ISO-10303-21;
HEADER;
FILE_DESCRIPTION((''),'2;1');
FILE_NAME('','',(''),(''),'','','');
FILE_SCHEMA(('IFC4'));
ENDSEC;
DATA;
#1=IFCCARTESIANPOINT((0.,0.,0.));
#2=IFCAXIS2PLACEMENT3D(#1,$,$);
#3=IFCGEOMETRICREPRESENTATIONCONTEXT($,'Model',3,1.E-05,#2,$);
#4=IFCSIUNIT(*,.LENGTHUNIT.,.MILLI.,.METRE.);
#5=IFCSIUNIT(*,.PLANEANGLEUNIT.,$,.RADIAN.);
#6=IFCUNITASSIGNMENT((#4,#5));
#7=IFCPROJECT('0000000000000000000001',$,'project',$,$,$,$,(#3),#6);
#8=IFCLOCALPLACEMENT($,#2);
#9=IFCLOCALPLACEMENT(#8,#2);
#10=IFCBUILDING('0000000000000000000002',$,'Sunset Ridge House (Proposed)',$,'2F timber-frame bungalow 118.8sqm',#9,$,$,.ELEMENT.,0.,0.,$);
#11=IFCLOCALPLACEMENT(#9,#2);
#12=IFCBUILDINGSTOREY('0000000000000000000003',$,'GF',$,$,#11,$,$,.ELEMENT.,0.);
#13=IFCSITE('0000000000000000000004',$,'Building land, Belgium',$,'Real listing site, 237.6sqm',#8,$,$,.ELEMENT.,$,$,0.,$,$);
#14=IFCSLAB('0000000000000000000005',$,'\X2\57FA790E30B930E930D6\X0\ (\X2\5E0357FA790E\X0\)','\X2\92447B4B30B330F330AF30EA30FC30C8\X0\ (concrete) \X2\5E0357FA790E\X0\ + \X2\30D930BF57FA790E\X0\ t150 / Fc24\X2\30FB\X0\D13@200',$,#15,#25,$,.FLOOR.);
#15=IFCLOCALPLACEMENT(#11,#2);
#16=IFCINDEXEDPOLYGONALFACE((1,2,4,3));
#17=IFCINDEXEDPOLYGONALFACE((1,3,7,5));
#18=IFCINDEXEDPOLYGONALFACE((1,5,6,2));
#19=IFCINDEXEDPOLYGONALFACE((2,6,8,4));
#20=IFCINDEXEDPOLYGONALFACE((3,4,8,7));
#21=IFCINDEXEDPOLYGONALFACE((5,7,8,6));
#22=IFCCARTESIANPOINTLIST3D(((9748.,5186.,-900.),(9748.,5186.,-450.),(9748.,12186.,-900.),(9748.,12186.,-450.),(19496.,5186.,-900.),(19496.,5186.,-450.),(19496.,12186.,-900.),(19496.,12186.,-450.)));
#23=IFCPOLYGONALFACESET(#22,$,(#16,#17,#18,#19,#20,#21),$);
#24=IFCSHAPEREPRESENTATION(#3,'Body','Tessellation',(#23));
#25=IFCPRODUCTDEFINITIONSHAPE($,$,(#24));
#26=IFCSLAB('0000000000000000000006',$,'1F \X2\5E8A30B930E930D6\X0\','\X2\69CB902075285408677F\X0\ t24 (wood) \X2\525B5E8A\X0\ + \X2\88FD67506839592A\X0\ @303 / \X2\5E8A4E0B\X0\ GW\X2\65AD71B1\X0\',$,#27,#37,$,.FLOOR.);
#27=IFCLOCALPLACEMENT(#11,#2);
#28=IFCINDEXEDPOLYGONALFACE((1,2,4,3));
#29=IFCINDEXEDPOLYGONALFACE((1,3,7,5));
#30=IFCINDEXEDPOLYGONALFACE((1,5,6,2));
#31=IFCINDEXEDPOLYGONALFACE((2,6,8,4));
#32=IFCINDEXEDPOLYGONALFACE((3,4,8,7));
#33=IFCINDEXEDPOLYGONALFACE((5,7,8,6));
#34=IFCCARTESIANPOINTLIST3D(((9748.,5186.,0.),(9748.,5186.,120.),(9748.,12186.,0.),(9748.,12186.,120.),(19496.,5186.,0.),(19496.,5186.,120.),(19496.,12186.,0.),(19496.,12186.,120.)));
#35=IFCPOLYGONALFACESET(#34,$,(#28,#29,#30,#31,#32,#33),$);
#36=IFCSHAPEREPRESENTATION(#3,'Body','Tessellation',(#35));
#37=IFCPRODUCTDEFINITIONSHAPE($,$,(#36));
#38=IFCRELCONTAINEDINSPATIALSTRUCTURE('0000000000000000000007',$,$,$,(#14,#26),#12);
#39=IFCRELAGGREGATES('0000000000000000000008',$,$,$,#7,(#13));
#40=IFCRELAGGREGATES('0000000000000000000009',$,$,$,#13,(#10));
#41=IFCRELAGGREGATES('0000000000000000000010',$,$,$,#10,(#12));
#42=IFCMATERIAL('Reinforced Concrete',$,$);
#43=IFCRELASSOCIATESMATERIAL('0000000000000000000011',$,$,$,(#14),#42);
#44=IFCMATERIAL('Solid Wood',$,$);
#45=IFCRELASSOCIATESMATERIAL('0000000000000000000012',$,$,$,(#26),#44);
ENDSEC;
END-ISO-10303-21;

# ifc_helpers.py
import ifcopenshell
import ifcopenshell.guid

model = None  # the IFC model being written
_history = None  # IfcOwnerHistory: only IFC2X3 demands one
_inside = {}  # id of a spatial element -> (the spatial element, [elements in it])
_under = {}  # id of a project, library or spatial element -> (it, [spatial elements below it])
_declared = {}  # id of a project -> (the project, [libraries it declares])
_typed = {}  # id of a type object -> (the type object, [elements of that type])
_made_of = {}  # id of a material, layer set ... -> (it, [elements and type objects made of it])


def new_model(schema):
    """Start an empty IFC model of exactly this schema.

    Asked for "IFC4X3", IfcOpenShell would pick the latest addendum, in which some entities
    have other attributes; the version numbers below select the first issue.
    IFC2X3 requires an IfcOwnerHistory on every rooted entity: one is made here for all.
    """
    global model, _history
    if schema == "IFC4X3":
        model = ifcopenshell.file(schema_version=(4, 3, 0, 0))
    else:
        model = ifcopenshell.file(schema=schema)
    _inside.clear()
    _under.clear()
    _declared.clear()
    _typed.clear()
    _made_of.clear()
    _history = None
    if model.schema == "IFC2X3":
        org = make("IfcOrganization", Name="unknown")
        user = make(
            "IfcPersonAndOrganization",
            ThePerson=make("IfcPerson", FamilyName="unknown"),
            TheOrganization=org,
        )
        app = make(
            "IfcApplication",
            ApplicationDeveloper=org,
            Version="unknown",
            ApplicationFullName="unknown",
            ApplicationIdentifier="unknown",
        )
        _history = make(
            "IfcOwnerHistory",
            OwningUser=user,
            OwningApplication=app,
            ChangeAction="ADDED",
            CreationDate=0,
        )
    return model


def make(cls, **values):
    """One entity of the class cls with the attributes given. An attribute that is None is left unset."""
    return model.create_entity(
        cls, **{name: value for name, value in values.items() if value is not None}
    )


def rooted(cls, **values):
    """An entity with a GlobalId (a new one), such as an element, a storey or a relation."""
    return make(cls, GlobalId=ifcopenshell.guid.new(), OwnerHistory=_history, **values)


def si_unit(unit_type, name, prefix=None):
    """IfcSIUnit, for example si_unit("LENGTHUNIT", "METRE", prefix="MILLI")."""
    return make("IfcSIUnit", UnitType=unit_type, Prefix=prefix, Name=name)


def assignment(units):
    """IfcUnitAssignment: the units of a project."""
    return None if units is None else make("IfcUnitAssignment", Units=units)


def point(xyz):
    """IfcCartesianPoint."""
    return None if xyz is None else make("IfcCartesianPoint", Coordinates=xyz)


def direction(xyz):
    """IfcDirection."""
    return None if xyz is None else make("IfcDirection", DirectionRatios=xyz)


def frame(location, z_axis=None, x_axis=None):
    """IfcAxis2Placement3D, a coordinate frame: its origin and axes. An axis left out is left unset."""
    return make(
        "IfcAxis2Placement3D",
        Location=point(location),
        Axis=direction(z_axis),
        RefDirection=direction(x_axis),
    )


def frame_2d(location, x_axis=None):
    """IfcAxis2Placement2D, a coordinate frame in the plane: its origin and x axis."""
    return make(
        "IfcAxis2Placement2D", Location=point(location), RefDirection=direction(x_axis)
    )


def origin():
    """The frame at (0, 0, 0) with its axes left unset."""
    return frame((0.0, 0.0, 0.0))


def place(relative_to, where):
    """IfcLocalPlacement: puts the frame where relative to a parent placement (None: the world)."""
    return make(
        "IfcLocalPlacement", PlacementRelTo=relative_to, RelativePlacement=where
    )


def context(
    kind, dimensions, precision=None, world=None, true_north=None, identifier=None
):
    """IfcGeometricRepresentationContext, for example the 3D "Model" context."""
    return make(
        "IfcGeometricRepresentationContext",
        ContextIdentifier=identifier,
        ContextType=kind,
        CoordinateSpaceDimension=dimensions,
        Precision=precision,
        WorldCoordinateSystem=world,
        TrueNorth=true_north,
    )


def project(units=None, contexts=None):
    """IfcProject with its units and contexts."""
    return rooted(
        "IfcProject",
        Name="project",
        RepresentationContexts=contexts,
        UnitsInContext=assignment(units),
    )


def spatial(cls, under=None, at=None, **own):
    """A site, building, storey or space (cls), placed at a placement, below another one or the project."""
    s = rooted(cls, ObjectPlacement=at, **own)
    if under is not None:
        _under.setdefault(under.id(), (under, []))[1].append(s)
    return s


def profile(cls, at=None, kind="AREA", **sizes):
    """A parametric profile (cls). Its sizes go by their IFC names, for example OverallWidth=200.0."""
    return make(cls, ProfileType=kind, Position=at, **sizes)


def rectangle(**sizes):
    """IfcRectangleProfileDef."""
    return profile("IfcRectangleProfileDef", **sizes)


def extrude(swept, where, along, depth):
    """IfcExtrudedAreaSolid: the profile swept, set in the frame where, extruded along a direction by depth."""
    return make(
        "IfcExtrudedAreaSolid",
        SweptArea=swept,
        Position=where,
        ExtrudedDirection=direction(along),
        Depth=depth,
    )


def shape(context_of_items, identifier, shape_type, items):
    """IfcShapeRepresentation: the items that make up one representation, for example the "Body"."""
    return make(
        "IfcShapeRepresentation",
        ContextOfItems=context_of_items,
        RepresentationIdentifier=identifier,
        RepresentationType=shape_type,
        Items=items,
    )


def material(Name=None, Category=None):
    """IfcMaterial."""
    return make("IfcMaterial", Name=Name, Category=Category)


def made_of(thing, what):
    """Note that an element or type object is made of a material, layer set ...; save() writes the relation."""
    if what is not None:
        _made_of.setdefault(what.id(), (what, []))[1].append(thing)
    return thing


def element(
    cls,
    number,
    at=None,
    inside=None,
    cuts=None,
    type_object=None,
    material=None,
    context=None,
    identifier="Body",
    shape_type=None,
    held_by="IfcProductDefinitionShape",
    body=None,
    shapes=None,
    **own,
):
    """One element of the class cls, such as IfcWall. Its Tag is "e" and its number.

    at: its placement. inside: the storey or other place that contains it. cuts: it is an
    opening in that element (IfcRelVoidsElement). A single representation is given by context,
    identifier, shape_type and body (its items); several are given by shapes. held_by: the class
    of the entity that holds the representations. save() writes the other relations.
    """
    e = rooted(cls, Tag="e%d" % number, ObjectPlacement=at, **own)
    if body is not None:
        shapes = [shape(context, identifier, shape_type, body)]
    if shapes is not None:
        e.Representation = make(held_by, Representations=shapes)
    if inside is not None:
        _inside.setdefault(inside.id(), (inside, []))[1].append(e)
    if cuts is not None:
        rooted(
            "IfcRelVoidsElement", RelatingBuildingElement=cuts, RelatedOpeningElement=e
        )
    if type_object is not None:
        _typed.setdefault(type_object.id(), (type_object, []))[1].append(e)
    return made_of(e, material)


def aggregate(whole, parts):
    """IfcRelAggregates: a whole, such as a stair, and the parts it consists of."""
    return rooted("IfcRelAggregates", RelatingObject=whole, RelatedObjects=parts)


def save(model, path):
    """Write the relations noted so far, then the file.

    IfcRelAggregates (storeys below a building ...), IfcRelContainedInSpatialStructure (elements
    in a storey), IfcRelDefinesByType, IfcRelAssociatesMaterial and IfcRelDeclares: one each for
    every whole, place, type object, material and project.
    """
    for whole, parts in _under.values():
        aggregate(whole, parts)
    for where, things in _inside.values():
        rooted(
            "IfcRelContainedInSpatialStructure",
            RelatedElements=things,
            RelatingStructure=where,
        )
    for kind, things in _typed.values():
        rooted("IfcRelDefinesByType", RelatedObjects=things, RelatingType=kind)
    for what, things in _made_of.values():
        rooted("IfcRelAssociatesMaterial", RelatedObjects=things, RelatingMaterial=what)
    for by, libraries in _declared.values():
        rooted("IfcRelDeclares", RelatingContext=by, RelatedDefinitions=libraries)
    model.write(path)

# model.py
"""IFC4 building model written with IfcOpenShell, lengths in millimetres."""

from ifc_helpers import new_model, si_unit, frame, frame_2d, origin, place, context, project, spatial, rectangle, extrude, material, element, save


model = new_model("IFC4")

# Units and contexts
model_context = context("Model", 3, precision=1e-05, world=origin())
ifc_project = project(units=[si_unit("LENGTHUNIT", "METRE", prefix="MILLI"), si_unit("PLANEANGLEUNIT", "RADIAN")], contexts=[model_context])

# Site, building, storey
site_placement = place(None, origin())
site = spatial("IfcSite", under=ifc_project, at=site_placement, Name="Building land, Belgium", ObjectType="Real listing site, 237.6sqm", CompositionType="ELEMENT", RefElevation=0.0)
building_placement = place(site_placement, origin())
building = spatial("IfcBuilding", under=site, at=building_placement, Name="Sunset Ridge House (Proposed)", ObjectType="2F timber-frame bungalow 118.8sqm", CompositionType="ELEMENT", ElevationOfRefHeight=0.0, ElevationOfTerrain=0.0)
storey_placement = place(building_placement, origin())
storey = spatial("IfcBuildingStorey", under=building, at=storey_placement, Name="GF", CompositionType="ELEMENT", Elevation=0.0)

# Slabs
ifc_material_1 = material(Name="Reinforced Concrete")
slab_1_placement = place(storey_placement, frame((4874.0, 2593.0, -450.0)))
element("IfcSlab", 1, at=slab_1_placement, inside=storey, material=ifc_material_1, Name="基礎スラブ (布基礎)", Description="鉄筋コンクリート (concrete) 布基礎 + ベタ基礎 t150 / Fc24・D13@200", PredefinedType="FLOOR", context=model_context, shape_type="SweptSolid", body=[
    extrude(rectangle(XDim=9748.0, YDim=7000.0, at=frame_2d((4874.0, 3500.0))), frame((4874.0, 2593.0, -450.0)), (0.0, 0.0, 1.0), 450.0),
])
ifc_material_2 = material(Name="Solid Wood")
slab_2_placement = place(storey_placement, frame((4874.0, 2593.0, 0.0)))
element("IfcSlab", 2, at=slab_2_placement, inside=storey, material=ifc_material_2, Name="1F 床スラブ", Description="構造用合板 t24 (wood) 剛床 + 製材根太 @303 / 床下 GW断熱", PredefinedType="FLOOR", context=model_context, shape_type="SweptSolid", body=[
    extrude(rectangle(XDim=9748.0, YDim=7000.0, at=frame_2d((4874.0, 3500.0))), frame((4874.0, 2593.0, 0.0)), (0.0, 0.0, 1.0), 120.0),
])

save(model, "model.ifc")
